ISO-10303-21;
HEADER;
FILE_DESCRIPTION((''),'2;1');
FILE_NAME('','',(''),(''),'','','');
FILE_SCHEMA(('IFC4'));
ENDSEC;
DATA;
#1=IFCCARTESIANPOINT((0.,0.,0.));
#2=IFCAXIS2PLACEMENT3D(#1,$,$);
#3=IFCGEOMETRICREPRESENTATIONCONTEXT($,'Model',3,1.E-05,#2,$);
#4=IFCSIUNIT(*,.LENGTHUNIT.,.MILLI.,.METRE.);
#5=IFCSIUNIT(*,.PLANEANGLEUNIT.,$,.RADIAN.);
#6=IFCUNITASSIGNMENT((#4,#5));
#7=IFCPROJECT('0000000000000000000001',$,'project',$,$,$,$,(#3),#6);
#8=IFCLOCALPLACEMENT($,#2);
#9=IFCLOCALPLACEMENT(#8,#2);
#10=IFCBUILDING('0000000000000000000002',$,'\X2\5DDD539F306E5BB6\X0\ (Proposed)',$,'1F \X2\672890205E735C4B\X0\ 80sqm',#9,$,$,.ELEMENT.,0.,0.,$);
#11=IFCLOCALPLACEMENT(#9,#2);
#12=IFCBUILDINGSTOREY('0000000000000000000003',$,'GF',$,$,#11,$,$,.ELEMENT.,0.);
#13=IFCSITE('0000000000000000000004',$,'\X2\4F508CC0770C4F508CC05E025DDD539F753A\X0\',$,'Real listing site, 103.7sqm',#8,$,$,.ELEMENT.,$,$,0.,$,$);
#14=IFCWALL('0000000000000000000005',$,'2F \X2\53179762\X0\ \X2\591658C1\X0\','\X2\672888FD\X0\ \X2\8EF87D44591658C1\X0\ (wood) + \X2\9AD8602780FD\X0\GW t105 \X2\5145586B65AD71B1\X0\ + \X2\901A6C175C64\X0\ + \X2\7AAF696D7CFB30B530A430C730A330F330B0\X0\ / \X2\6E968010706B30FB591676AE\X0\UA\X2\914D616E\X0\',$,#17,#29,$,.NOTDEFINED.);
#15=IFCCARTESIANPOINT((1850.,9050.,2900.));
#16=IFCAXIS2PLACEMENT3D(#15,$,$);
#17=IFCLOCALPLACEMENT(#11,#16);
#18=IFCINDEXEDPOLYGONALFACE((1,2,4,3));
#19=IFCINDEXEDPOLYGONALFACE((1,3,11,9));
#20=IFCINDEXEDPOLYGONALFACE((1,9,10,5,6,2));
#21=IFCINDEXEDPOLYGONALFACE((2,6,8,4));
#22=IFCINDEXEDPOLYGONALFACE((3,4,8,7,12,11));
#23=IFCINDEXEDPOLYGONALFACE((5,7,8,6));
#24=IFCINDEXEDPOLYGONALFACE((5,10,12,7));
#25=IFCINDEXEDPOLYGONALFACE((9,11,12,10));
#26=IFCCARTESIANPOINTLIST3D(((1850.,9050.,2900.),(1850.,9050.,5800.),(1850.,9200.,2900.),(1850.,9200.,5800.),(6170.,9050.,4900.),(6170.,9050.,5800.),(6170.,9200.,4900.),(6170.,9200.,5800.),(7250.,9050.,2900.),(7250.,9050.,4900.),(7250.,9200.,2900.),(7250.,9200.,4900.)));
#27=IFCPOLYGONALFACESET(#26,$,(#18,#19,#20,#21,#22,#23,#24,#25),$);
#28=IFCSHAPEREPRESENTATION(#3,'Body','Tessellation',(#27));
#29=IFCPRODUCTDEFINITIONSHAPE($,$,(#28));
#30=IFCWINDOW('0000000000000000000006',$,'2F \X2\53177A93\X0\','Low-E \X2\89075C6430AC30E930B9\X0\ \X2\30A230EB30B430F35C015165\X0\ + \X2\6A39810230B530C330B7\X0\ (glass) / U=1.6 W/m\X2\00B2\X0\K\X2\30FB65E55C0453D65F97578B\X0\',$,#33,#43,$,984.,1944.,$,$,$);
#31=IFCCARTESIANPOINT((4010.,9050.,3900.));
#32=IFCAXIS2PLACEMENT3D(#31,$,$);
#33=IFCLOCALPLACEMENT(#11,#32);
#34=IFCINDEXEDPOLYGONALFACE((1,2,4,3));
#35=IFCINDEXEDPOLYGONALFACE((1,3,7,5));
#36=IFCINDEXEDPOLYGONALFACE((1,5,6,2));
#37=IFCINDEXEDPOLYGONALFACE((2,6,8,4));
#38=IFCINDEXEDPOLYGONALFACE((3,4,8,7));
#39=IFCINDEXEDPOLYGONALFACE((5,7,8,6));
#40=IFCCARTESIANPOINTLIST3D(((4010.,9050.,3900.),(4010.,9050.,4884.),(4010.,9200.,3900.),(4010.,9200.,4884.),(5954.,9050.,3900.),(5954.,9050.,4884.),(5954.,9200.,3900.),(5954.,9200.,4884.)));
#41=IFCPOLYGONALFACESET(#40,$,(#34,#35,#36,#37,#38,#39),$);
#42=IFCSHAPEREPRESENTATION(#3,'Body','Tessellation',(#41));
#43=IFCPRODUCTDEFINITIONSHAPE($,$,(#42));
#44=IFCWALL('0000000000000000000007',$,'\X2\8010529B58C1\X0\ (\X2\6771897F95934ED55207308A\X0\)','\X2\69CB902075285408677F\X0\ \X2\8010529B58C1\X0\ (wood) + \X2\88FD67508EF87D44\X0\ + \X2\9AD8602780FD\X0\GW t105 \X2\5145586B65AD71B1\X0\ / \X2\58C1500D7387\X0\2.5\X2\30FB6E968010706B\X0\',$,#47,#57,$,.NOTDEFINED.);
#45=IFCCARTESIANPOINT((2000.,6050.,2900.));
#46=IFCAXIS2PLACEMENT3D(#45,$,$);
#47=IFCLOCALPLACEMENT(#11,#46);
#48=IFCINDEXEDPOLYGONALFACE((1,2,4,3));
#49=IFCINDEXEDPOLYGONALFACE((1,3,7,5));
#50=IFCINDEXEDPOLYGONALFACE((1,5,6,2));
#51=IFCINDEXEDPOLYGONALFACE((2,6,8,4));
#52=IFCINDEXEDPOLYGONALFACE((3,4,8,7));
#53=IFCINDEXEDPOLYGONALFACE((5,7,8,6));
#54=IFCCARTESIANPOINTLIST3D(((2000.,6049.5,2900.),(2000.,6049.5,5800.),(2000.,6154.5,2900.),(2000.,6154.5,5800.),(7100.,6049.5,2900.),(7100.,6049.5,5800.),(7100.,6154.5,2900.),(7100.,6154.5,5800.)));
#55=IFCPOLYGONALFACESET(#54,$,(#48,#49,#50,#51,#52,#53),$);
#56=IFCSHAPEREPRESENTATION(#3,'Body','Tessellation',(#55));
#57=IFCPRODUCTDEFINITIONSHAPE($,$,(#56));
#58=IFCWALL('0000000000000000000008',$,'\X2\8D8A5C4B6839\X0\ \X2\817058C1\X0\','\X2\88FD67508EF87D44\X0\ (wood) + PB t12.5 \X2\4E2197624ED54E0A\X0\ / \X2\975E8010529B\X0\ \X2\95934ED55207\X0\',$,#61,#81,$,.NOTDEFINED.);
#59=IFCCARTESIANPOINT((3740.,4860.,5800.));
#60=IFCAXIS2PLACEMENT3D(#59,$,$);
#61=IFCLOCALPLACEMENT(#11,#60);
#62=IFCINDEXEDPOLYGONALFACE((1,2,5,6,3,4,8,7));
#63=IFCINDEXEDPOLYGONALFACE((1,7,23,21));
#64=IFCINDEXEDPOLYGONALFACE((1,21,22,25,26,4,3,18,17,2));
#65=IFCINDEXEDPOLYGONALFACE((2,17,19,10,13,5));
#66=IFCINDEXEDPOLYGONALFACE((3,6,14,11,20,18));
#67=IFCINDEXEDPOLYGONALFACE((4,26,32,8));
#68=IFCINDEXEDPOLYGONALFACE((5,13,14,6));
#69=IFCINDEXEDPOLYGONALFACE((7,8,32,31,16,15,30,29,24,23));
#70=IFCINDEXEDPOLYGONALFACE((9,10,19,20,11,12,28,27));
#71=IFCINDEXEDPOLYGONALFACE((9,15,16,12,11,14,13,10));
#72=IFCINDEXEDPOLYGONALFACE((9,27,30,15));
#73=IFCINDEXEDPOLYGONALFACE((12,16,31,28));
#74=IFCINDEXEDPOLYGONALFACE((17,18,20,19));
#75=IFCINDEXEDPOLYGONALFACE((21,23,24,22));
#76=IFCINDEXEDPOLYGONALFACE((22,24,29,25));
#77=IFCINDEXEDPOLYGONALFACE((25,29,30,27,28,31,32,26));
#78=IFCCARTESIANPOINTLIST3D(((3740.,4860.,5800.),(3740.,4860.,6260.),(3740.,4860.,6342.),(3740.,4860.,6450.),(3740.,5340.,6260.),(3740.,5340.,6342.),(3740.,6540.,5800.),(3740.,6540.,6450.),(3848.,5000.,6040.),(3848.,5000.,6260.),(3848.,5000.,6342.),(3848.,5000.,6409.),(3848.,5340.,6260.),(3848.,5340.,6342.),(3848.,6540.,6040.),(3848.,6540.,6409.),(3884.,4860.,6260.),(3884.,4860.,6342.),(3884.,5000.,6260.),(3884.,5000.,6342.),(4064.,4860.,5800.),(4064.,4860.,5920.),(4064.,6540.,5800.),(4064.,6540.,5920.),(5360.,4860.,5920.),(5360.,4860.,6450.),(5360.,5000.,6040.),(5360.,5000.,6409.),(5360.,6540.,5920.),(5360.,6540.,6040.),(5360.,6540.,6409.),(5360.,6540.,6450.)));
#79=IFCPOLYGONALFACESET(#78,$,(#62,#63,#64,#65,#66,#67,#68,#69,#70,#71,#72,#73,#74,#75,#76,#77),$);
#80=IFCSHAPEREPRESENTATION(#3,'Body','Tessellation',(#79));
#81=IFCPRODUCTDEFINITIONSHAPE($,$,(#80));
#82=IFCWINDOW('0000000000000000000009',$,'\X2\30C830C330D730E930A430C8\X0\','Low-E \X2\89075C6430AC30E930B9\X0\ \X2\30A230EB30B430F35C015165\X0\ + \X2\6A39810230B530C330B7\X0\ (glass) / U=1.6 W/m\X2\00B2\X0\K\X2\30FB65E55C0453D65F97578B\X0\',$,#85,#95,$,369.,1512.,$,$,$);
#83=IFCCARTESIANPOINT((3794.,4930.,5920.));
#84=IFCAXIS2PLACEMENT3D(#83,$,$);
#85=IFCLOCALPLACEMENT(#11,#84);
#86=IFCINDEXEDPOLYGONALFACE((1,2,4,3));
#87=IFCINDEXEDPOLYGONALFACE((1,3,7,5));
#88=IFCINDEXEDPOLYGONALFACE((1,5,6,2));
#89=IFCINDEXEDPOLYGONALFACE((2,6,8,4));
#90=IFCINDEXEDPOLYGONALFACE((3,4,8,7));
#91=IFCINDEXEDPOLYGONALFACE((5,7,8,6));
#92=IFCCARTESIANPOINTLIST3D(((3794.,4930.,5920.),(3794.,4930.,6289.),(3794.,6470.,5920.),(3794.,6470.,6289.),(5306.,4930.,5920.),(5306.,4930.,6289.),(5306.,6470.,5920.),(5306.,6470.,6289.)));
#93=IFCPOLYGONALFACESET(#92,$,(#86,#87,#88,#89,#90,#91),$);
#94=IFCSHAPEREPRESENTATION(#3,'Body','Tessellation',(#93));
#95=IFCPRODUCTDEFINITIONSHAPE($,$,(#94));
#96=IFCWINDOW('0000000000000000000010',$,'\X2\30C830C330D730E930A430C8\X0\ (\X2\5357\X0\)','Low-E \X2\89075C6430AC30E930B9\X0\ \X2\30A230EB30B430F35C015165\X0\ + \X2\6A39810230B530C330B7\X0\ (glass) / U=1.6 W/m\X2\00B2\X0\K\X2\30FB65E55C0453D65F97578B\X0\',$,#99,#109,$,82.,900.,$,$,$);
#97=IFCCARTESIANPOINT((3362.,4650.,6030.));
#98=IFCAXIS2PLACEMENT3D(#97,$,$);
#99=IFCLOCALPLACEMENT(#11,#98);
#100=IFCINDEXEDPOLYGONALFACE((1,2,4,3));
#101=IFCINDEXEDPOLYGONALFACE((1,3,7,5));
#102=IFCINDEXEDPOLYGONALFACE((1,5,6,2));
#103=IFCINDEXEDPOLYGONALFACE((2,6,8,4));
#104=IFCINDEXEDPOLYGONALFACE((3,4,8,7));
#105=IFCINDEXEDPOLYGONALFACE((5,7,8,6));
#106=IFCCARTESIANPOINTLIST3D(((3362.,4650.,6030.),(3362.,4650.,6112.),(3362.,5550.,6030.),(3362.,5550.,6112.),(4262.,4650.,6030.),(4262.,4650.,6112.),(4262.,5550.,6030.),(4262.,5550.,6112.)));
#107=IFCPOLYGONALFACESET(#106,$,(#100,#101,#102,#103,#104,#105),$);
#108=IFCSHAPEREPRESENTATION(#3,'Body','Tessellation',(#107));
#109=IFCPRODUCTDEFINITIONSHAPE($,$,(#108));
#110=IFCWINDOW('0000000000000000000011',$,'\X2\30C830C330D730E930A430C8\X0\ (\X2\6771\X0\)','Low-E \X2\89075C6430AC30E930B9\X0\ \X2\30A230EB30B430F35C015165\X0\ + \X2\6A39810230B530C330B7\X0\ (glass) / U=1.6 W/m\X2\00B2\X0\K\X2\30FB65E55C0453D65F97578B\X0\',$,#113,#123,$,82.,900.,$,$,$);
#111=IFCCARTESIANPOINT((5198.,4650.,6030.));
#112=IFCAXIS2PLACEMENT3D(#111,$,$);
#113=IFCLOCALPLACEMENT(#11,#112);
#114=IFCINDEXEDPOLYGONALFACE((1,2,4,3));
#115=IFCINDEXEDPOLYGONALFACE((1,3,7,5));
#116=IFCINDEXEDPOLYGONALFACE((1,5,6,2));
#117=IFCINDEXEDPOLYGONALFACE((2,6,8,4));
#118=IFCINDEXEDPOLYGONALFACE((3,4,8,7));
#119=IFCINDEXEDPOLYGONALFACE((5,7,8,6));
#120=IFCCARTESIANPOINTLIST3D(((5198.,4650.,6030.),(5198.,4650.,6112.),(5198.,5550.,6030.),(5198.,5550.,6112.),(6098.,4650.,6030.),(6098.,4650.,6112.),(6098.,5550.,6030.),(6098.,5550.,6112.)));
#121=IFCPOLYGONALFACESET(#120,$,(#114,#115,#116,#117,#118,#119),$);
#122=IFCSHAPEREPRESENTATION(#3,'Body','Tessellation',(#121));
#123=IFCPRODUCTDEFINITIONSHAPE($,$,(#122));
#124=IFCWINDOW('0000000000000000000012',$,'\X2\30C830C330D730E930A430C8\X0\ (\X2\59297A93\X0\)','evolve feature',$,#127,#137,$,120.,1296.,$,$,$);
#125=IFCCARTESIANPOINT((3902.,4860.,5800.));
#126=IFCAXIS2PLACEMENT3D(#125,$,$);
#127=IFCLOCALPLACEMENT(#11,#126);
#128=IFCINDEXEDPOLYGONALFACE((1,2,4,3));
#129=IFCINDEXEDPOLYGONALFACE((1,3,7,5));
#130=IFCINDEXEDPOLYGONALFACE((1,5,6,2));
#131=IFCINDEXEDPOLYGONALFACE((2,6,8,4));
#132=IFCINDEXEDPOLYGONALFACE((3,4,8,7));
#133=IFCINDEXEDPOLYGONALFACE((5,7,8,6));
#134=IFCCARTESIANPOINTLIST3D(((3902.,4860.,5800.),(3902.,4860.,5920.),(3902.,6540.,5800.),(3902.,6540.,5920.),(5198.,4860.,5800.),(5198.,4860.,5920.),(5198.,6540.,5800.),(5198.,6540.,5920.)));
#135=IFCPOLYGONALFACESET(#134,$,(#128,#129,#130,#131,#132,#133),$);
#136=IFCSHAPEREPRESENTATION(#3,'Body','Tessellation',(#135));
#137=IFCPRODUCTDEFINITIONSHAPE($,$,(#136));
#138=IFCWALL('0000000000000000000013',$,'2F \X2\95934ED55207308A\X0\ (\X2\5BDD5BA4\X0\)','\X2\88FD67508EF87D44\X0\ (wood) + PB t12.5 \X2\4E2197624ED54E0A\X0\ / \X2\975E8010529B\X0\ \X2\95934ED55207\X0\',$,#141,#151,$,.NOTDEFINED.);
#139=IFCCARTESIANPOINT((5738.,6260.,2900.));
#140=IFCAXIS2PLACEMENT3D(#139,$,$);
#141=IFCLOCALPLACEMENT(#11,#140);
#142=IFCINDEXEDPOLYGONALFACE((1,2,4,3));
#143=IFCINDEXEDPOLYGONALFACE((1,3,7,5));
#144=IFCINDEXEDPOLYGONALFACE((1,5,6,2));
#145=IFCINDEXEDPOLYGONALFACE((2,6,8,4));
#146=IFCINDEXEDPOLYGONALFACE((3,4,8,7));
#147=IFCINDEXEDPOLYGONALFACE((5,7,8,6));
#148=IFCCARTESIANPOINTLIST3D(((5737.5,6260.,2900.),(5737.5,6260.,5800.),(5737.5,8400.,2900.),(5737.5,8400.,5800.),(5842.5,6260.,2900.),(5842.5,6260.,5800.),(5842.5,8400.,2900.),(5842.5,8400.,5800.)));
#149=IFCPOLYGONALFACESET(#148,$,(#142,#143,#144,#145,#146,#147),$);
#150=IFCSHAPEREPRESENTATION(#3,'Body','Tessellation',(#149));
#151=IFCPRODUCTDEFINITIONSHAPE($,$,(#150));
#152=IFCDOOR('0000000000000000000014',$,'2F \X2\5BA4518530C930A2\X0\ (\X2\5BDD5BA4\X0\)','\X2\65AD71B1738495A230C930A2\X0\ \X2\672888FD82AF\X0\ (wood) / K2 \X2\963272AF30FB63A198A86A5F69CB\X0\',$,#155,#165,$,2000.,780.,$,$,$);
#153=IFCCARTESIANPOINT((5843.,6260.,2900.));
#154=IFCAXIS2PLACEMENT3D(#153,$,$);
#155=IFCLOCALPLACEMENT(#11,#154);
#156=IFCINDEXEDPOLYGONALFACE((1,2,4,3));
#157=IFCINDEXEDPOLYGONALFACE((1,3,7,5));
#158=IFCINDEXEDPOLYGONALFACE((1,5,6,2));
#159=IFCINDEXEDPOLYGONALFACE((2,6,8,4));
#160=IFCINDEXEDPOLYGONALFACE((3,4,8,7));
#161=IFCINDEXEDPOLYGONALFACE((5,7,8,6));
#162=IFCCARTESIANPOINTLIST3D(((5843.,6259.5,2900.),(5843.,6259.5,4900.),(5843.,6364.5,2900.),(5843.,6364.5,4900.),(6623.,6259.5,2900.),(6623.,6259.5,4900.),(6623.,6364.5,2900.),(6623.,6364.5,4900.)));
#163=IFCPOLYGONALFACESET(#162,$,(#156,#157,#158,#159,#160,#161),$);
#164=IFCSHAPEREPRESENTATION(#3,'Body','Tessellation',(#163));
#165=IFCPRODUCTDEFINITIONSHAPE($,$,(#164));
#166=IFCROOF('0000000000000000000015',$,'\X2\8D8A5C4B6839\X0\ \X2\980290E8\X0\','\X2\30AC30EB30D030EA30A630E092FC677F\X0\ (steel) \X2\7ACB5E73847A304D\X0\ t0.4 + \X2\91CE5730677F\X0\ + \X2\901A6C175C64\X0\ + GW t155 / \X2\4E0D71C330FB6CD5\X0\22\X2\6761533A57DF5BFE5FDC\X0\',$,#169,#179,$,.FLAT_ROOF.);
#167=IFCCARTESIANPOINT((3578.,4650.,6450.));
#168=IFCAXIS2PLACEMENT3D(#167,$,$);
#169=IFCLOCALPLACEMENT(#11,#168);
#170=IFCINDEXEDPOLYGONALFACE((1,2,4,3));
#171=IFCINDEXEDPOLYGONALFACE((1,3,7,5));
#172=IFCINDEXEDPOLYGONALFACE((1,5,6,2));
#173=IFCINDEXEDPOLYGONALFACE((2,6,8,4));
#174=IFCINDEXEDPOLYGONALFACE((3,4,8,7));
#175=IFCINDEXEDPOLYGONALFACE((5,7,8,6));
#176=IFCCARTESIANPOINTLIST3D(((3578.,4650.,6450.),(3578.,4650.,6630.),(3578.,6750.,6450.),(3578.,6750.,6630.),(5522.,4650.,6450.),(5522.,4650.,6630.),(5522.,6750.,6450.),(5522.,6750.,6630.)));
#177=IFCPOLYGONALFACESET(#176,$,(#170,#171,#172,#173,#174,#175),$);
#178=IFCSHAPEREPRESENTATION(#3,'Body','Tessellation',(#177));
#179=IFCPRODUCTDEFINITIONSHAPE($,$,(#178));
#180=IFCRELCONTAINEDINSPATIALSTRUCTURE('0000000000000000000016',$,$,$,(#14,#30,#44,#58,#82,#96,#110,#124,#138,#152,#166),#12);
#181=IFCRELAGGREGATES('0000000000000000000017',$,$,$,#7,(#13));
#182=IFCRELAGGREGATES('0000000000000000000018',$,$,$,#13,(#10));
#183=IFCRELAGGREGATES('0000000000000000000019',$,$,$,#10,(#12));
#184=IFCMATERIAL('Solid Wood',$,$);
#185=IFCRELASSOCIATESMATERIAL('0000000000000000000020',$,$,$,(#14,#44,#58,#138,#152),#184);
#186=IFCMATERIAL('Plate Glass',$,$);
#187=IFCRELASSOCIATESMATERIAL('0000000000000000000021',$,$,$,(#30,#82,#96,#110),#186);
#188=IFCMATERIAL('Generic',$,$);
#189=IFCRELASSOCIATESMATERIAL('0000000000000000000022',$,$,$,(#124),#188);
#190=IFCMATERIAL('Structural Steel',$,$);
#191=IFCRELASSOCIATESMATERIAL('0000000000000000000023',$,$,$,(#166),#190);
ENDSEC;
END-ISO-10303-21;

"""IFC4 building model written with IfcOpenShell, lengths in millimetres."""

from ifc_helpers import new_model, si_unit, frame, frame_2d, origin, place, context, project, spatial, rectangle, extrude, material, element, fill, save


model = new_model("IFC4")

# Units and contexts
model_context = context("Model", 3, precision=1e-05, world=origin())
ifc_project = project(units=[si_unit("LENGTHUNIT", "METRE", prefix="MILLI"), si_unit("PLANEANGLEUNIT", "RADIAN")], contexts=[model_context])

# Site, building, storey
site_placement = place(None, origin())
site = spatial("IfcSite", under=ifc_project, at=site_placement, Name="佐賀県佐賀市川原町", ObjectType="Real listing site, 103.7sqm", CompositionType="ELEMENT", RefElevation=0.0)
building_placement = place(site_placement, origin())
building = spatial("IfcBuilding", under=site, at=building_placement, Name="川原の家 (Proposed)", ObjectType="1F 木造平屋 80sqm", CompositionType="ELEMENT", ElevationOfRefHeight=0.0, ElevationOfTerrain=0.0)
storey_placement = place(building_placement, origin())
storey = spatial("IfcBuildingStorey", under=building, at=storey_placement, Name="GF", CompositionType="ELEMENT", Elevation=0.0)

# Wall, opening, window
ifc_material_1 = material(Name="Solid Wood")
wall_1_placement = place(storey_placement, frame((1850.0, 9050.0, 2900.0)))
wall_1 = element("IfcWall", 1, at=wall_1_placement, inside=storey, material=ifc_material_1, Name="2F 北面 外壁", Description="木製 軸組外壁 (wood) + 高性能GW t105 充填断熱 + 通気層 + 窯業系サイディング / 準耐火・外皮UA配慮", PredefinedType="NOTDEFINED", context=model_context, shape_type="SweptSolid", body=[
    extrude(rectangle(XDim=5400.0, YDim=150.0, at=frame_2d((2700.0, 75.0))), frame((1850.0, 9050.0, 2900.0)), (0.0, 0.0, 1.0), 2900.0),
])
opening_1_placement = place(storey_placement, frame((4010.0, 9050.0, 3900.0)))
opening_1 = element("IfcOpeningElement", 2, at=opening_1_placement, cuts=wall_1, PredefinedType="NOTDEFINED", context=model_context, shape_type="SweptSolid", body=[
    extrude(rectangle(XDim=1944.0, YDim=150.0, at=frame_2d((972.0, 75.0))), frame((4010.0, 9050.0, 3900.0)), (0.0, 0.0, 1.0), 984.0),
])
ifc_material_2 = material(Name="Plate Glass")
window_1_placement = place(storey_placement, frame((4010.0, 9050.0, 3900.0)))
window_1 = element("IfcWindow", 3, at=window_1_placement, inside=storey, material=ifc_material_2, Name="2F 北窓", Description="Low-E 複層ガラス アルゴン封入 + 樹脂サッシ (glass) / U=1.6 W/m²K・日射取得型", OverallHeight=984.0, OverallWidth=1944.0, context=model_context, shape_type="SweptSolid", body=[
    extrude(rectangle(XDim=1944.0, YDim=150.0, at=frame_2d((972.0, 75.0))), frame((4010.0, 9050.0, 3900.0)), (0.0, 0.0, 1.0), 984.0),
])
fill(opening_1, window_1)

# Wall
wall_2_placement = place(storey_placement, frame((2000.0, 6050.0, 2900.0)))
element("IfcWall", 4, at=wall_2_placement, inside=storey, material=ifc_material_1, Name="耐力壁 (東西間仕切り)", Description="構造用合板 耐力壁 (wood) + 製材軸組 + 高性能GW t105 充填断熱 / 壁倍率2.5・準耐火", PredefinedType="NOTDEFINED", context=model_context, shape_type="SweptSolid", body=[
    extrude(rectangle(XDim=5100.0, YDim=105.0, at=frame_2d((2550.0, 52.0))), frame((2000.0, 6050.0, 2900.0)), (0.0, 0.0, 1.0), 2900.0),
])

# Wall, openings, windows
wall_3_placement = place(storey_placement, frame((3740.0, 4860.0, 5800.0)))
wall_3 = element("IfcWall", 5, at=wall_3_placement, inside=storey, material=ifc_material_1, Name="越屋根 腰壁", Description="製材軸組 (wood) + PB t12.5 両面仕上 / 非耐力 間仕切", PredefinedType="NOTDEFINED", context=model_context, shape_type="SweptSolid", body=[
    extrude(rectangle(XDim=1620.0, YDim=1680.0, at=frame_2d((810.0, 840.0))), frame((3740.0, 4860.0, 5800.0)), (0.0, 0.0, 1.0), 650.0),
])
opening_2_placement = place(storey_placement, frame((3794.0, 4930.0, 5920.0)))
opening_2 = element("IfcOpeningElement", 6, at=opening_2_placement, cuts=wall_3, PredefinedType="NOTDEFINED", context=model_context, shape_type="SweptSolid", body=[
    extrude(rectangle(XDim=1512.0, YDim=1540.0, at=frame_2d((756.0, 770.0))), frame((3794.0, 4930.0, 5920.0)), (0.0, 0.0, 1.0), 369.0),
])
opening_3_placement = place(storey_placement, frame((3362.0, 4650.0, 6030.0)))
opening_3 = element("IfcOpeningElement", 7, at=opening_3_placement, cuts=wall_3, PredefinedType="NOTDEFINED", context=model_context, shape_type="SweptSolid", body=[
    extrude(rectangle(XDim=900.0, YDim=900.0, at=frame_2d((450.0, 450.0))), frame((3362.0, 4650.0, 6030.0)), (0.0, 0.0, 1.0), 82.0),
])
opening_4_placement = place(storey_placement, frame((5198.0, 4650.0, 6030.0)))
opening_4 = element("IfcOpeningElement", 8, at=opening_4_placement, cuts=wall_3, PredefinedType="NOTDEFINED", context=model_context, shape_type="SweptSolid", body=[
    extrude(rectangle(XDim=900.0, YDim=900.0, at=frame_2d((450.0, 450.0))), frame((5198.0, 4650.0, 6030.0)), (0.0, 0.0, 1.0), 82.0),
])
opening_5_placement = place(storey_placement, frame((3902.0, 4860.0, 5800.0)))
opening_5 = element("IfcOpeningElement", 9, at=opening_5_placement, cuts=wall_3, PredefinedType="NOTDEFINED", context=model_context, shape_type="SweptSolid", body=[
    extrude(rectangle(XDim=1296.0, YDim=1680.0, at=frame_2d((648.0, 840.0))), frame((3902.0, 4860.0, 5800.0)), (0.0, 0.0, 1.0), 120.0),
])
window_2_placement = place(storey_placement, frame((3794.0, 4930.0, 5920.0)))
window_2 = element("IfcWindow", 10, at=window_2_placement, inside=storey, material=ifc_material_2, Name="トップライト", Description="Low-E 複層ガラス アルゴン封入 + 樹脂サッシ (glass) / U=1.6 W/m²K・日射取得型", OverallHeight=369.0, OverallWidth=1512.0, context=model_context, shape_type="SweptSolid", body=[
    extrude(rectangle(XDim=1512.0, YDim=1540.0, at=frame_2d((756.0, 770.0))), frame((3794.0, 4930.0, 5920.0)), (0.0, 0.0, 1.0), 369.0),
])
fill(opening_2, window_2)
window_3_placement = place(storey_placement, frame((3362.0, 4650.0, 6030.0)))
window_3 = element("IfcWindow", 11, at=window_3_placement, inside=storey, material=ifc_material_2, Name="トップライト (南)", Description="Low-E 複層ガラス アルゴン封入 + 樹脂サッシ (glass) / U=1.6 W/m²K・日射取得型", OverallHeight=82.0, OverallWidth=900.0, context=model_context, shape_type="SweptSolid", body=[
    extrude(rectangle(XDim=900.0, YDim=900.0, at=frame_2d((450.0, 450.0))), frame((3362.0, 4650.0, 6030.0)), (0.0, 0.0, 1.0), 82.0),
])
fill(opening_3, window_3)
window_4_placement = place(storey_placement, frame((5198.0, 4650.0, 6030.0)))
window_4 = element("IfcWindow", 12, at=window_4_placement, inside=storey, material=ifc_material_2, Name="トップライト (東)", Description="Low-E 複層ガラス アルゴン封入 + 樹脂サッシ (glass) / U=1.6 W/m²K・日射取得型", OverallHeight=82.0, OverallWidth=900.0, context=model_context, shape_type="SweptSolid", body=[
    extrude(rectangle(XDim=900.0, YDim=900.0, at=frame_2d((450.0, 450.0))), frame((5198.0, 4650.0, 6030.0)), (0.0, 0.0, 1.0), 82.0),
])
fill(opening_4, window_4)
ifc_material_3 = material(Name="Generic")
window_5_placement = place(storey_placement, frame((3902.0, 4860.0, 5800.0)))
window_5 = element("IfcWindow", 13, at=window_5_placement, inside=storey, material=ifc_material_3, Name="トップライト (天窓)", Description="evolve feature", OverallHeight=120.0, OverallWidth=1296.0, context=model_context, shape_type="SweptSolid", body=[
    extrude(rectangle(XDim=1296.0, YDim=1680.0, at=frame_2d((648.0, 840.0))), frame((3902.0, 4860.0, 5800.0)), (0.0, 0.0, 1.0), 120.0),
])
fill(opening_5, window_5)

# Wall
wall_4_placement = place(storey_placement, frame((5738.0, 6260.0, 2900.0)))
element("IfcWall", 14, at=wall_4_placement, inside=storey, material=ifc_material_1, Name="2F 間仕切り (寝室)", Description="製材軸組 (wood) + PB t12.5 両面仕上 / 非耐力 間仕切", PredefinedType="NOTDEFINED", context=model_context, shape_type="SweptSolid", body=[
    extrude(rectangle(XDim=105.0, YDim=2140.0, at=frame_2d((52.0, 1070.0))), frame((5738.0, 6260.0, 2900.0)), (0.0, 0.0, 1.0), 2900.0),
])

# Door
door_placement = place(storey_placement, frame((5843.0, 6260.0, 2900.0)))
element("IfcDoor", 15, at=door_placement, inside=storey, material=ifc_material_1, Name="2F 室内ドア (寝室)", Description="断熱玄関ドア 木製芯 (wood) / K2 防犯・採風機構", OverallHeight=2000.0, OverallWidth=780.0, context=model_context, shape_type="SweptSolid", body=[
    extrude(rectangle(XDim=780.0, YDim=105.0, at=frame_2d((390.0, 52.0))), frame((5843.0, 6260.0, 2900.0)), (0.0, 0.0, 1.0), 2000.0),
])

# Roof
ifc_material_4 = material(Name="Structural Steel")
roof_placement = place(storey_placement, frame((3578.0, 4650.0, 6450.0)))
element("IfcRoof", 16, at=roof_placement, inside=storey, material=ifc_material_4, Name="越屋根 頂部", Description="ガルバリウム鋼板 (steel) 立平葺き t0.4 + 野地板 + 通気層 + GW t155 / 不燃・法22条区域対応", PredefinedType="FLAT_ROOF", context=model_context, shape_type="SweptSolid", body=[
    extrude(rectangle(XDim=1944.0, YDim=2100.0, at=frame_2d((972.0, 1050.0))), frame((3578.0, 4650.0, 6450.0)), (0.0, 0.0, 1.0), 180.0),
])

save(model, "model.ifc")
